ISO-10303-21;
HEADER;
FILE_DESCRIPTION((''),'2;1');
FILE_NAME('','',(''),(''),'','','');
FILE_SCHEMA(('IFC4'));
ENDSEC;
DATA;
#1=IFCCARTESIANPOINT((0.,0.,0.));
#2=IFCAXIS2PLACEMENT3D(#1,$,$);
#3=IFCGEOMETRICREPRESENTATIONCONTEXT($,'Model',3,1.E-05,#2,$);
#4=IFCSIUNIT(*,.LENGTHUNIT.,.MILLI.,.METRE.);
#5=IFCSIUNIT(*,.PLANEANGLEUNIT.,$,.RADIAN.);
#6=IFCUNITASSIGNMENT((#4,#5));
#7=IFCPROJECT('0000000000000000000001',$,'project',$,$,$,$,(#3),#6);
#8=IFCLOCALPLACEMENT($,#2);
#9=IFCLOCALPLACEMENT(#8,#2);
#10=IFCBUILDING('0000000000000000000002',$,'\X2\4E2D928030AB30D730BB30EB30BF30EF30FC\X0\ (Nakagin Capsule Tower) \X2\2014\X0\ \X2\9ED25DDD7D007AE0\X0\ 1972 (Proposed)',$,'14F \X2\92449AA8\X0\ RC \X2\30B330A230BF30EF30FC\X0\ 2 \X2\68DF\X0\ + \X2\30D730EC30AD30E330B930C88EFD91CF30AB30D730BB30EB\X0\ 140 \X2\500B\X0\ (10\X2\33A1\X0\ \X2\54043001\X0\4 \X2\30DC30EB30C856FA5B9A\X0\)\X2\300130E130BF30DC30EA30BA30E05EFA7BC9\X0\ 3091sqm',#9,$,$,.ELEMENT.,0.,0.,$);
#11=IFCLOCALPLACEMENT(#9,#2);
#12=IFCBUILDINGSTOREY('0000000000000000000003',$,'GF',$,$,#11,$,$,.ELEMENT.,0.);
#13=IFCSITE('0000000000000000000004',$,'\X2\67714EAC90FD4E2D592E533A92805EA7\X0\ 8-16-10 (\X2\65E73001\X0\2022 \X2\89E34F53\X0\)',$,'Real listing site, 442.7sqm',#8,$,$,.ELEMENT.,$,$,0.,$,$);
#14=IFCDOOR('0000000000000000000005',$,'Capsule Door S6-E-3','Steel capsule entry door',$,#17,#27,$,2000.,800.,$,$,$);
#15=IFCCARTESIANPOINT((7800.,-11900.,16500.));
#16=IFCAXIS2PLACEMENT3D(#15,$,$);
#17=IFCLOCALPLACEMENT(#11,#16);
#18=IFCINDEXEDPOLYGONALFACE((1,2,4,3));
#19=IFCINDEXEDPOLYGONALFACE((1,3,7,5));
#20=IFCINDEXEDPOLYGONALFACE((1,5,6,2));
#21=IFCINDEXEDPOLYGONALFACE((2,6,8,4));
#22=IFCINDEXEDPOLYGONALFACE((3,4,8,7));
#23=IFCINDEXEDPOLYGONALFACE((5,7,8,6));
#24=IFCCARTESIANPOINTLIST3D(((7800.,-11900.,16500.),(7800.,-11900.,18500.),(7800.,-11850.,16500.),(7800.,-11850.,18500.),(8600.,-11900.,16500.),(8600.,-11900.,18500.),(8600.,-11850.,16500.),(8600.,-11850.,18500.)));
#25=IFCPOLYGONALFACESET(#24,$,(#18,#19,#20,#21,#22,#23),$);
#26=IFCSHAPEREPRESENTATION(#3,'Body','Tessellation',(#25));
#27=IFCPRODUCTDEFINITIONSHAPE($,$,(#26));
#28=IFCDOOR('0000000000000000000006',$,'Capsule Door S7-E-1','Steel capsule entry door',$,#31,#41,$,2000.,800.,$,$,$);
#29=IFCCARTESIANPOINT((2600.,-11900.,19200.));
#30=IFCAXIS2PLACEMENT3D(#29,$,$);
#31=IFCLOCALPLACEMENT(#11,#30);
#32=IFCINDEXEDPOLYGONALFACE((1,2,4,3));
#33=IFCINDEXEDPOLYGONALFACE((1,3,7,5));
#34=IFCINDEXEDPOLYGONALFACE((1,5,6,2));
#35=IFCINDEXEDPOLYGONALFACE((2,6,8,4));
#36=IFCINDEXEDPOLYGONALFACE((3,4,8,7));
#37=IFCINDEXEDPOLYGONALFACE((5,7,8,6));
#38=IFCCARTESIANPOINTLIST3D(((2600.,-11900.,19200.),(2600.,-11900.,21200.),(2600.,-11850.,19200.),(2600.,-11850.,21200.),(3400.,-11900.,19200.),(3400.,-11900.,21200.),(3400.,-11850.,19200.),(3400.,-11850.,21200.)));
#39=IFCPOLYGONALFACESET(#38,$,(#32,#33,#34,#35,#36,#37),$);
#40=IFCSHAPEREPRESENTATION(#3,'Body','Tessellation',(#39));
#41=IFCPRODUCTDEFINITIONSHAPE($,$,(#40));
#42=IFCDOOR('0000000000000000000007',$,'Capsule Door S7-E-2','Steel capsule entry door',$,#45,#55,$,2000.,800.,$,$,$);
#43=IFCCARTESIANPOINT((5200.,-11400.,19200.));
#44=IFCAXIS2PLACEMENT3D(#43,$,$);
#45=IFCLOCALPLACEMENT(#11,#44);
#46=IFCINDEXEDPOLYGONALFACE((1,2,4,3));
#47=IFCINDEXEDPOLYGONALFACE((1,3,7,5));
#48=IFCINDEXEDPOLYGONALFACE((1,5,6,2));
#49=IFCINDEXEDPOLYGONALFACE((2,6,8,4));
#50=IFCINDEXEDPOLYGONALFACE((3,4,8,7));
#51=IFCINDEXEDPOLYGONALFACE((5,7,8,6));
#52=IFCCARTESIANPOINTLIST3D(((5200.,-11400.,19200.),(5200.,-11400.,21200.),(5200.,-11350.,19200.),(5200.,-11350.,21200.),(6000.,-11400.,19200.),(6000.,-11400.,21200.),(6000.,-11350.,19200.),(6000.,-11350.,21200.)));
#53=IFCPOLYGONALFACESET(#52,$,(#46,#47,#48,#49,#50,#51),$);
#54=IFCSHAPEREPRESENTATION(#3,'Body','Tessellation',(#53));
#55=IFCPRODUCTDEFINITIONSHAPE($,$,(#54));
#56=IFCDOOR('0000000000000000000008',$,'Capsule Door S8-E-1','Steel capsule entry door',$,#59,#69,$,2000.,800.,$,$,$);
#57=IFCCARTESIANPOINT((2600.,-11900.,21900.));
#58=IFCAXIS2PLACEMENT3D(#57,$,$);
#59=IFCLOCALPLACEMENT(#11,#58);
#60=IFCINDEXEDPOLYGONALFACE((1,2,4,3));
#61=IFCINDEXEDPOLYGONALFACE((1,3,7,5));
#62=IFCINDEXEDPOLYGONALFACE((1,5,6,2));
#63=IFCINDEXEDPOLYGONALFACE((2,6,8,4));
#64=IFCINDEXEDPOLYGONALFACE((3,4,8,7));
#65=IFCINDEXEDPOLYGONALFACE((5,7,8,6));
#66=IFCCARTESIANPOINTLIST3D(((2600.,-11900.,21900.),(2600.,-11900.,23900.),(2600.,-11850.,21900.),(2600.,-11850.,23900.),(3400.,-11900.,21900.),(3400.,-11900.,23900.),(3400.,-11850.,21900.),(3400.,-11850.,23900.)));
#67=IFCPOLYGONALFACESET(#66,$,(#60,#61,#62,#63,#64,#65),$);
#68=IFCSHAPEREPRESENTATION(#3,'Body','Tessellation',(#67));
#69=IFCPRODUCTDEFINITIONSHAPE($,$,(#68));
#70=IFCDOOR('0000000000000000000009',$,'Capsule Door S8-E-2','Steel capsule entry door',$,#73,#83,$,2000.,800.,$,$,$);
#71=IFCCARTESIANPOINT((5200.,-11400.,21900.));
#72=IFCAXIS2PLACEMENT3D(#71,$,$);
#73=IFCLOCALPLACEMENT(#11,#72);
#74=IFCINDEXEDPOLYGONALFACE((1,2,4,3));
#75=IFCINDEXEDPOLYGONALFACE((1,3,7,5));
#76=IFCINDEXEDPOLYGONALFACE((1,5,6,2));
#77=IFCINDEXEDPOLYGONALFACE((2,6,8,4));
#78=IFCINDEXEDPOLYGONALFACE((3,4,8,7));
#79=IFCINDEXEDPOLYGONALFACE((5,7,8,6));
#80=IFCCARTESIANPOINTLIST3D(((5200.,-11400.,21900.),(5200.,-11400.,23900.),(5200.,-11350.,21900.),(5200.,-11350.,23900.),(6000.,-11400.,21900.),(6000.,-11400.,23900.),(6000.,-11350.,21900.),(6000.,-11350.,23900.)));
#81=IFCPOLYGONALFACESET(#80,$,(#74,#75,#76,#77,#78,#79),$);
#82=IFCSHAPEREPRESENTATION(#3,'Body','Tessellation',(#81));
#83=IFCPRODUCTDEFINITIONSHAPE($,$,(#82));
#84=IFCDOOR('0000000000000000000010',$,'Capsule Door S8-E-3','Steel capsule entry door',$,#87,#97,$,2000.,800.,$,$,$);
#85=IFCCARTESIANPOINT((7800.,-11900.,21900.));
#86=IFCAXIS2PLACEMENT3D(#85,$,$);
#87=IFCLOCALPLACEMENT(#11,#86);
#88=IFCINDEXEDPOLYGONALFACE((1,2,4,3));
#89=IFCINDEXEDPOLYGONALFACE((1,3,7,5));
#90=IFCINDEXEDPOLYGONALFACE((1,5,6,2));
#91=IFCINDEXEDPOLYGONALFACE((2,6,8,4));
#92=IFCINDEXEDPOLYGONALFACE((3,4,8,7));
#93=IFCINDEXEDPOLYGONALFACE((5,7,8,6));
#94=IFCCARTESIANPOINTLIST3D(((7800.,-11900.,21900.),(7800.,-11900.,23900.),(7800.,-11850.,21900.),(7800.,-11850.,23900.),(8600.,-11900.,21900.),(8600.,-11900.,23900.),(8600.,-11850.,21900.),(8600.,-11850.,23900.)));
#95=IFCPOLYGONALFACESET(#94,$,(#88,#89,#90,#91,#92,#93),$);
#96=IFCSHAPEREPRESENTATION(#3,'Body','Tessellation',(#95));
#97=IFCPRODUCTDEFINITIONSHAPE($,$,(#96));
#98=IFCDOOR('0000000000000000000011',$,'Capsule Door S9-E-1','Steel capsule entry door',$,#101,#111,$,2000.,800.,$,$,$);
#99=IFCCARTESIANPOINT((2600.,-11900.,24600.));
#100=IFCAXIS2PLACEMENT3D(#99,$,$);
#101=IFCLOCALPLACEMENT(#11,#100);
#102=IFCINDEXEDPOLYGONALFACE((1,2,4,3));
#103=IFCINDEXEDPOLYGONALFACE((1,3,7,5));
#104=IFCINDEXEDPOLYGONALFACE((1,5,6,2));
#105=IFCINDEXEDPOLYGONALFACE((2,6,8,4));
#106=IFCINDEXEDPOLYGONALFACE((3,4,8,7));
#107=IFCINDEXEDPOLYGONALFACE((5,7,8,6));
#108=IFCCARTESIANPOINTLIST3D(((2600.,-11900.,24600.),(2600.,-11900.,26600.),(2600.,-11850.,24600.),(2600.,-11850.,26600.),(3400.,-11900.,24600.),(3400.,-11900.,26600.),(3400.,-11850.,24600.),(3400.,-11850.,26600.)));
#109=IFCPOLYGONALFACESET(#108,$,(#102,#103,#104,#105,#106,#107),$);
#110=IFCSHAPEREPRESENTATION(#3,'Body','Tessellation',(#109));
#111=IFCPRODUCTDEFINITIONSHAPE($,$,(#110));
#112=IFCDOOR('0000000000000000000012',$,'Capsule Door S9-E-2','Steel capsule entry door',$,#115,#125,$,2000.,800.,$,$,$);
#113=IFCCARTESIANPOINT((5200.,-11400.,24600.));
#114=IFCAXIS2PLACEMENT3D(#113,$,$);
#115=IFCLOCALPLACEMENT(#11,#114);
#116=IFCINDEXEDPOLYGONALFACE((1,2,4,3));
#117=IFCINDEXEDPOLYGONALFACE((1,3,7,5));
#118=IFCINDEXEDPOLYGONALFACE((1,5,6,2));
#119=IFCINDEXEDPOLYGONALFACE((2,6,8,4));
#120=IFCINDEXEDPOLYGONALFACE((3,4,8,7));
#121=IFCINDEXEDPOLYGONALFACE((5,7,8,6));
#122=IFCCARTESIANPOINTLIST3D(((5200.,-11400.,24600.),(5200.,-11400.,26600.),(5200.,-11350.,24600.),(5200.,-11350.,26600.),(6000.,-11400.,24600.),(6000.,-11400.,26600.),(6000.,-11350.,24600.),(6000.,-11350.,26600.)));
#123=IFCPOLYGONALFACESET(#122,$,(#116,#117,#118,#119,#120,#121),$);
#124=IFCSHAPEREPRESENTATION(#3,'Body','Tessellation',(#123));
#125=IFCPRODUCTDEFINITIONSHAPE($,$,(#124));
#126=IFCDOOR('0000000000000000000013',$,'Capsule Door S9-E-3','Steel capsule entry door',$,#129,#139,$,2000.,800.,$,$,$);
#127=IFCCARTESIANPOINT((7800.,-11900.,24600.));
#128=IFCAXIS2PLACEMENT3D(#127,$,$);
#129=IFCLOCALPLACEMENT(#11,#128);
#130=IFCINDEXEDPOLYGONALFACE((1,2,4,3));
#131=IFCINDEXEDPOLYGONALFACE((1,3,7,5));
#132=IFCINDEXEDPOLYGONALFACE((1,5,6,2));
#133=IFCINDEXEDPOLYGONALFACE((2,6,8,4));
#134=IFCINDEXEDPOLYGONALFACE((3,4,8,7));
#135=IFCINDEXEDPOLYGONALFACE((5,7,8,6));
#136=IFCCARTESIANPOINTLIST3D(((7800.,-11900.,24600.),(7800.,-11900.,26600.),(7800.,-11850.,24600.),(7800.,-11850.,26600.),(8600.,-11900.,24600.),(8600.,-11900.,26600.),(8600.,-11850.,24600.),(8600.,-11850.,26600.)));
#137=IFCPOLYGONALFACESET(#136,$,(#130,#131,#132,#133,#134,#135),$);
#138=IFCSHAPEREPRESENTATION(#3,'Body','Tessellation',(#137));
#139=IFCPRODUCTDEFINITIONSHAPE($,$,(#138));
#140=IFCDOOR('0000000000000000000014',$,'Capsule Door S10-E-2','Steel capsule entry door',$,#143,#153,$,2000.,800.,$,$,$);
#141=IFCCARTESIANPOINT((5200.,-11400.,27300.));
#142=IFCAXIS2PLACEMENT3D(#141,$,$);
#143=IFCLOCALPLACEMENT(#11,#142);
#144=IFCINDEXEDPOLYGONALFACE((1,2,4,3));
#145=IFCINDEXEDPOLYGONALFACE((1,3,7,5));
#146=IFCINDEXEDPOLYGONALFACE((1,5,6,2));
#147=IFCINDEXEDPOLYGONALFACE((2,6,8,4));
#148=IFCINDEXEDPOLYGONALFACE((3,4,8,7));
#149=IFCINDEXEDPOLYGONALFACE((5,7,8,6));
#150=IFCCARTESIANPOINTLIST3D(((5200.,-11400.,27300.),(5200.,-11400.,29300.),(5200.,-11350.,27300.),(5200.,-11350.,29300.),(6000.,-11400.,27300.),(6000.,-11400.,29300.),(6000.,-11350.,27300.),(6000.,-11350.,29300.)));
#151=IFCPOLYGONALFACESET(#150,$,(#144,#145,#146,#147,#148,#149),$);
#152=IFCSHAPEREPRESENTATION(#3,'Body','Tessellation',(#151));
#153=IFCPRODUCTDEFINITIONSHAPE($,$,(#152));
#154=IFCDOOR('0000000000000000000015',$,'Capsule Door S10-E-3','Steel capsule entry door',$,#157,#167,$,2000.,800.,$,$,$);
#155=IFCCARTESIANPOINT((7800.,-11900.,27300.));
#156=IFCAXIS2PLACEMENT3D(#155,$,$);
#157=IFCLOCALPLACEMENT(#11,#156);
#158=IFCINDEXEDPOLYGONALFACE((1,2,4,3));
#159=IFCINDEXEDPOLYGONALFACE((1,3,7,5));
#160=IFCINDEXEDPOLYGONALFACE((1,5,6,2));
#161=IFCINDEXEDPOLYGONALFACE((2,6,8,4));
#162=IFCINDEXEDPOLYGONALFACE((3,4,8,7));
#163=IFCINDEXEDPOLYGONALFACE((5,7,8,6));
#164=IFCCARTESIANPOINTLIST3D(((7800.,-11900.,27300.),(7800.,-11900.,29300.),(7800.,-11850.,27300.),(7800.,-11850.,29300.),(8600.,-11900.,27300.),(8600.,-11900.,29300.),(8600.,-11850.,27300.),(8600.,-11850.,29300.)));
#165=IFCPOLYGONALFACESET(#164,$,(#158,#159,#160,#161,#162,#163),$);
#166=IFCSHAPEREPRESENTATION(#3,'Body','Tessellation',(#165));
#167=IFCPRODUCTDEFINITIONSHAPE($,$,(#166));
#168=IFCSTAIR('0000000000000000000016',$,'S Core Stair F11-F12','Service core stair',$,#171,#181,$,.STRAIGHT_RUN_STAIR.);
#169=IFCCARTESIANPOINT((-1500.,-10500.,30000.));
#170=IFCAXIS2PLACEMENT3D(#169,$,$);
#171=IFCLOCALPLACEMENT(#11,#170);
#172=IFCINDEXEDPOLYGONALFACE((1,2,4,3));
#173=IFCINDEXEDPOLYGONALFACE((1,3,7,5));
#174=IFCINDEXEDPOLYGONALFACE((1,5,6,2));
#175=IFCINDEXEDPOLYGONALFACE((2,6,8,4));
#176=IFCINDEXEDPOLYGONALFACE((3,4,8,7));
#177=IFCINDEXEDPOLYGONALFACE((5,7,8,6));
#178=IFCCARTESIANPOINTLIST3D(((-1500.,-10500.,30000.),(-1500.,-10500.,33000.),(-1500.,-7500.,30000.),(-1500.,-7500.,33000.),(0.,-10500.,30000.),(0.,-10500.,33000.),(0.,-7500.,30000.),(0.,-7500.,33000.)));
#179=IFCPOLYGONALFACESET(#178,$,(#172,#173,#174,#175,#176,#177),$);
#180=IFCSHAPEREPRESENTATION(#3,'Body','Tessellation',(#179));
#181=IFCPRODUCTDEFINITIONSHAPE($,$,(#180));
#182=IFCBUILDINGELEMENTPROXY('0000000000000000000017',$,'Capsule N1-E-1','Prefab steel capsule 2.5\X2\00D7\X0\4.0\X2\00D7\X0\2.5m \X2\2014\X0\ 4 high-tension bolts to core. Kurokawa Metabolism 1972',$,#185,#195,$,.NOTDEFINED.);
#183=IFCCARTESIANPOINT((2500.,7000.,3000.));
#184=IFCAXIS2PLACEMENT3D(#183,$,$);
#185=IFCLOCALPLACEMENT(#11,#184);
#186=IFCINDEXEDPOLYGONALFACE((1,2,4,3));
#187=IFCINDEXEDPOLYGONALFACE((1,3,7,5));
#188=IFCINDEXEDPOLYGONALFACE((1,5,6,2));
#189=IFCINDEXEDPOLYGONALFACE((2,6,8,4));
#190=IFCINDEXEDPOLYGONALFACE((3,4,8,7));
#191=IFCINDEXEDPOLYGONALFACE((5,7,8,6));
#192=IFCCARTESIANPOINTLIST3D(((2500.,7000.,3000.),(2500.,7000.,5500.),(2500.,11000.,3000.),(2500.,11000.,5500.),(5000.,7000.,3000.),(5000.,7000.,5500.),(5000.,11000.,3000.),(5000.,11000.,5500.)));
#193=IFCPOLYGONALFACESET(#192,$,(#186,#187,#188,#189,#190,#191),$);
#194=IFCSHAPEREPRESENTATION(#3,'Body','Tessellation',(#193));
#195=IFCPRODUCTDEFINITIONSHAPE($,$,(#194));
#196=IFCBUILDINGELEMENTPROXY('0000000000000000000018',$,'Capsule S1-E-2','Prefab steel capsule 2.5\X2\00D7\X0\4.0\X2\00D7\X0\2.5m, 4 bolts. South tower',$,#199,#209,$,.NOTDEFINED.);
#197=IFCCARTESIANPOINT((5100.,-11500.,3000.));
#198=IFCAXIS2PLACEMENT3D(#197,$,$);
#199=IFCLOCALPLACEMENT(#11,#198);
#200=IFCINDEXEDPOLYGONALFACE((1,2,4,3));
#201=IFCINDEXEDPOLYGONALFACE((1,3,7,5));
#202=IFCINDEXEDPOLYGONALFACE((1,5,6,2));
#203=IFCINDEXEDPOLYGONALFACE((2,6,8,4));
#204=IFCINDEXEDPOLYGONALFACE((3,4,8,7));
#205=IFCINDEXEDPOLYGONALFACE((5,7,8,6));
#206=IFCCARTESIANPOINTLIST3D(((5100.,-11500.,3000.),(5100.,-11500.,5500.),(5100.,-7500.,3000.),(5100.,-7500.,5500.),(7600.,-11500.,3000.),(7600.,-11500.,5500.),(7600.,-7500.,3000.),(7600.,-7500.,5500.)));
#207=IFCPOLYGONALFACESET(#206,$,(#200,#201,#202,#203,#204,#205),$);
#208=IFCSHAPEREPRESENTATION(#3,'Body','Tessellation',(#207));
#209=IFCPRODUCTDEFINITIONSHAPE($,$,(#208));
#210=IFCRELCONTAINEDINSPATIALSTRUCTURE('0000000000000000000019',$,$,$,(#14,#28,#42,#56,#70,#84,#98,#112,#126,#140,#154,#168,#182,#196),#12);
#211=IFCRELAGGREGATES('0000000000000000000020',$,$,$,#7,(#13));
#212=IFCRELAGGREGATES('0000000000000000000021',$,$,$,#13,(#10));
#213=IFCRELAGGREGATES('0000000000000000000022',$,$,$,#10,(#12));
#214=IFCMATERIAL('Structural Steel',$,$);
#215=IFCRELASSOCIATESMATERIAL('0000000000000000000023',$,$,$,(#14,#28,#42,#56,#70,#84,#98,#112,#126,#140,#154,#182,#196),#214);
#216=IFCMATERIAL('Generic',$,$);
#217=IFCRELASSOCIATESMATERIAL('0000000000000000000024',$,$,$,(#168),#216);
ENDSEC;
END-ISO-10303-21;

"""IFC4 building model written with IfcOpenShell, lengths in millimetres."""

from ifc_helpers import new_model, si_unit, frame, frame_2d, origin, place, context, project, spatial, rectangle, extrude, material, element, save


model = new_model("IFC4")

# Units and contexts
model_context = context("Model", 3, precision=1e-05, world=origin())
ifc_project = project(units=[si_unit("LENGTHUNIT", "METRE", prefix="MILLI"), si_unit("PLANEANGLEUNIT", "RADIAN")], contexts=[model_context])

# Site, building, storey
site_placement = place(None, origin())
site = spatial("IfcSite", under=ifc_project, at=site_placement, Name="東京都中央区銀座 8-16-10 (旧、2022 解体)", ObjectType="Real listing site, 442.7sqm", CompositionType="ELEMENT", RefElevation=0.0)
building_placement = place(site_placement, origin())
building = spatial("IfcBuilding", under=site, at=building_placement, Name="中銀カプセルタワー (Nakagin Capsule Tower) — 黒川紀章 1972 (Proposed)", ObjectType="14F 鉄骨 RC コアタワー 2 棟 + プレキャスト軽量カプセル 140 個 (10㎡ 各、4 ボルト固定)、メタボリズム建築 3091sqm", CompositionType="ELEMENT", ElevationOfRefHeight=0.0, ElevationOfTerrain=0.0)
storey_placement = place(building_placement, origin())
storey = spatial("IfcBuildingStorey", under=building, at=storey_placement, Name="GF", CompositionType="ELEMENT", Elevation=0.0)

# Doors
ifc_material_1 = material(Name="Structural Steel")
door_1_placement = place(storey_placement, frame((7800.0, -11900.0, 16500.0)))
element("IfcDoor", 1, at=door_1_placement, inside=storey, material=ifc_material_1, Name="Capsule Door S6-E-3", Description="Steel capsule entry door", OverallHeight=2000.0, OverallWidth=800.0, context=model_context, shape_type="SweptSolid", body=[
    extrude(rectangle(XDim=800.0, YDim=50.0, at=frame_2d((400.0, 25.0))), frame((7800.0, -11900.0, 16500.0)), (0.0, 0.0, 1.0), 2000.0),
])
door_2_placement = place(storey_placement, frame((2600.0, -11900.0, 19200.0)))
element("IfcDoor", 2, at=door_2_placement, inside=storey, material=ifc_material_1, Name="Capsule Door S7-E-1", Description="Steel capsule entry door", OverallHeight=2000.0, OverallWidth=800.0, context=model_context, shape_type="SweptSolid", body=[
    extrude(rectangle(XDim=800.0, YDim=50.0, at=frame_2d((400.0, 25.0))), frame((2600.0, -11900.0, 19200.0)), (0.0, 0.0, 1.0), 2000.0),
])
door_3_placement = place(storey_placement, frame((5200.0, -11400.0, 19200.0)))
element("IfcDoor", 3, at=door_3_placement, inside=storey, material=ifc_material_1, Name="Capsule Door S7-E-2", Description="Steel capsule entry door", OverallHeight=2000.0, OverallWidth=800.0, context=model_context, shape_type="SweptSolid", body=[
    extrude(rectangle(XDim=800.0, YDim=50.0, at=frame_2d((400.0, 25.0))), frame((5200.0, -11400.0, 19200.0)), (0.0, 0.0, 1.0), 2000.0),
])
door_4_placement = place(storey_placement, frame((2600.0, -11900.0, 21900.0)))
element("IfcDoor", 4, at=door_4_placement, inside=storey, material=ifc_material_1, Name="Capsule Door S8-E-1", Description="Steel capsule entry door", OverallHeight=2000.0, OverallWidth=800.0, context=model_context, shape_type="SweptSolid", body=[
    extrude(rectangle(XDim=800.0, YDim=50.0, at=frame_2d((400.0, 25.0))), frame((2600.0, -11900.0, 21900.0)), (0.0, 0.0, 1.0), 2000.0),
])
door_5_placement = place(storey_placement, frame((5200.0, -11400.0, 21900.0)))
element("IfcDoor", 5, at=door_5_placement, inside=storey, material=ifc_material_1, Name="Capsule Door S8-E-2", Description="Steel capsule entry door", OverallHeight=2000.0, OverallWidth=800.0, context=model_context, shape_type="SweptSolid", body=[
    extrude(rectangle(XDim=800.0, YDim=50.0, at=frame_2d((400.0, 25.0))), frame((5200.0, -11400.0, 21900.0)), (0.0, 0.0, 1.0), 2000.0),
])
door_6_placement = place(storey_placement, frame((7800.0, -11900.0, 21900.0)))
element("IfcDoor", 6, at=door_6_placement, inside=storey, material=ifc_material_1, Name="Capsule Door S8-E-3", Description="Steel capsule entry door", OverallHeight=2000.0, OverallWidth=800.0, context=model_context, shape_type="SweptSolid", body=[
    extrude(rectangle(XDim=800.0, YDim=50.0, at=frame_2d((400.0, 25.0))), frame((7800.0, -11900.0, 21900.0)), (0.0, 0.0, 1.0), 2000.0),
])
door_7_placement = place(storey_placement, frame((2600.0, -11900.0, 24600.0)))
element("IfcDoor", 7, at=door_7_placement, inside=storey, material=ifc_material_1, Name="Capsule Door S9-E-1", Description="Steel capsule entry door", OverallHeight=2000.0, OverallWidth=800.0, context=model_context, shape_type="SweptSolid", body=[
    extrude(rectangle(XDim=800.0, YDim=50.0, at=frame_2d((400.0, 25.0))), frame((2600.0, -11900.0, 24600.0)), (0.0, 0.0, 1.0), 2000.0),
])
door_8_placement = place(storey_placement, frame((5200.0, -11400.0, 24600.0)))
element("IfcDoor", 8, at=door_8_placement, inside=storey, material=ifc_material_1, Name="Capsule Door S9-E-2", Description="Steel capsule entry door", OverallHeight=2000.0, OverallWidth=800.0, context=model_context, shape_type="SweptSolid", body=[
    extrude(rectangle(XDim=800.0, YDim=50.0, at=frame_2d((400.0, 25.0))), frame((5200.0, -11400.0, 24600.0)), (0.0, 0.0, 1.0), 2000.0),
])
door_9_placement = place(storey_placement, frame((7800.0, -11900.0, 24600.0)))
element("IfcDoor", 9, at=door_9_placement, inside=storey, material=ifc_material_1, Name="Capsule Door S9-E-3", Description="Steel capsule entry door", OverallHeight=2000.0, OverallWidth=800.0, context=model_context, shape_type="SweptSolid", body=[
    extrude(rectangle(XDim=800.0, YDim=50.0, at=frame_2d((400.0, 25.0))), frame((7800.0, -11900.0, 24600.0)), (0.0, 0.0, 1.0), 2000.0),
])
door_10_placement = place(storey_placement, frame((5200.0, -11400.0, 27300.0)))
element("IfcDoor", 10, at=door_10_placement, inside=storey, material=ifc_material_1, Name="Capsule Door S10-E-2", Description="Steel capsule entry door", OverallHeight=2000.0, OverallWidth=800.0, context=model_context, shape_type="SweptSolid", body=[
    extrude(rectangle(XDim=800.0, YDim=50.0, at=frame_2d((400.0, 25.0))), frame((5200.0, -11400.0, 27300.0)), (0.0, 0.0, 1.0), 2000.0),
])
door_11_placement = place(storey_placement, frame((7800.0, -11900.0, 27300.0)))
element("IfcDoor", 11, at=door_11_placement, inside=storey, material=ifc_material_1, Name="Capsule Door S10-E-3", Description="Steel capsule entry door", OverallHeight=2000.0, OverallWidth=800.0, context=model_context, shape_type="SweptSolid", body=[
    extrude(rectangle(XDim=800.0, YDim=50.0, at=frame_2d((400.0, 25.0))), frame((7800.0, -11900.0, 27300.0)), (0.0, 0.0, 1.0), 2000.0),
])

# Stair
ifc_material_2 = material(Name="Generic")
stair_placement = place(storey_placement, frame((-1500.0, -10500.0, 30000.0)))
element("IfcStair", 12, at=stair_placement, inside=storey, material=ifc_material_2, Name="S Core Stair F11-F12", Description="Service core stair", PredefinedType="STRAIGHT_RUN_STAIR", context=model_context, shape_type="SweptSolid", body=[
    extrude(rectangle(XDim=1500.0, YDim=3000.0, at=frame_2d((750.0, 1500.0))), frame((-1500.0, -10500.0, 30000.0)), (0.0, 0.0, 1.0), 3000.0),
])

# Building element proxies
proxy_1_placement = place(storey_placement, frame((2500.0, 7000.0, 3000.0)))
element("IfcBuildingElementProxy", 13, at=proxy_1_placement, inside=storey, material=ifc_material_1, Name="Capsule N1-E-1", Description="Prefab steel capsule 2.5×4.0×2.5m — 4 high-tension bolts to core. Kurokawa Metabolism 1972", PredefinedType="NOTDEFINED", context=model_context, shape_type="SweptSolid", body=[
    extrude(rectangle(XDim=2500.0, YDim=4000.0, at=frame_2d((1250.0, 2000.0))), frame((2500.0, 7000.0, 3000.0)), (0.0, 0.0, 1.0), 2500.0),
])
proxy_2_placement = place(storey_placement, frame((5100.0, -11500.0, 3000.0)))
element("IfcBuildingElementProxy", 14, at=proxy_2_placement, inside=storey, material=ifc_material_1, Name="Capsule S1-E-2", Description="Prefab steel capsule 2.5×4.0×2.5m, 4 bolts. South tower", PredefinedType="NOTDEFINED", context=model_context, shape_type="SweptSolid", body=[
    extrude(rectangle(XDim=2500.0, YDim=4000.0, at=frame_2d((1250.0, 2000.0))), frame((5100.0, -11500.0, 3000.0)), (0.0, 0.0, 1.0), 2500.0),
])

save(model, "model.ifc")
